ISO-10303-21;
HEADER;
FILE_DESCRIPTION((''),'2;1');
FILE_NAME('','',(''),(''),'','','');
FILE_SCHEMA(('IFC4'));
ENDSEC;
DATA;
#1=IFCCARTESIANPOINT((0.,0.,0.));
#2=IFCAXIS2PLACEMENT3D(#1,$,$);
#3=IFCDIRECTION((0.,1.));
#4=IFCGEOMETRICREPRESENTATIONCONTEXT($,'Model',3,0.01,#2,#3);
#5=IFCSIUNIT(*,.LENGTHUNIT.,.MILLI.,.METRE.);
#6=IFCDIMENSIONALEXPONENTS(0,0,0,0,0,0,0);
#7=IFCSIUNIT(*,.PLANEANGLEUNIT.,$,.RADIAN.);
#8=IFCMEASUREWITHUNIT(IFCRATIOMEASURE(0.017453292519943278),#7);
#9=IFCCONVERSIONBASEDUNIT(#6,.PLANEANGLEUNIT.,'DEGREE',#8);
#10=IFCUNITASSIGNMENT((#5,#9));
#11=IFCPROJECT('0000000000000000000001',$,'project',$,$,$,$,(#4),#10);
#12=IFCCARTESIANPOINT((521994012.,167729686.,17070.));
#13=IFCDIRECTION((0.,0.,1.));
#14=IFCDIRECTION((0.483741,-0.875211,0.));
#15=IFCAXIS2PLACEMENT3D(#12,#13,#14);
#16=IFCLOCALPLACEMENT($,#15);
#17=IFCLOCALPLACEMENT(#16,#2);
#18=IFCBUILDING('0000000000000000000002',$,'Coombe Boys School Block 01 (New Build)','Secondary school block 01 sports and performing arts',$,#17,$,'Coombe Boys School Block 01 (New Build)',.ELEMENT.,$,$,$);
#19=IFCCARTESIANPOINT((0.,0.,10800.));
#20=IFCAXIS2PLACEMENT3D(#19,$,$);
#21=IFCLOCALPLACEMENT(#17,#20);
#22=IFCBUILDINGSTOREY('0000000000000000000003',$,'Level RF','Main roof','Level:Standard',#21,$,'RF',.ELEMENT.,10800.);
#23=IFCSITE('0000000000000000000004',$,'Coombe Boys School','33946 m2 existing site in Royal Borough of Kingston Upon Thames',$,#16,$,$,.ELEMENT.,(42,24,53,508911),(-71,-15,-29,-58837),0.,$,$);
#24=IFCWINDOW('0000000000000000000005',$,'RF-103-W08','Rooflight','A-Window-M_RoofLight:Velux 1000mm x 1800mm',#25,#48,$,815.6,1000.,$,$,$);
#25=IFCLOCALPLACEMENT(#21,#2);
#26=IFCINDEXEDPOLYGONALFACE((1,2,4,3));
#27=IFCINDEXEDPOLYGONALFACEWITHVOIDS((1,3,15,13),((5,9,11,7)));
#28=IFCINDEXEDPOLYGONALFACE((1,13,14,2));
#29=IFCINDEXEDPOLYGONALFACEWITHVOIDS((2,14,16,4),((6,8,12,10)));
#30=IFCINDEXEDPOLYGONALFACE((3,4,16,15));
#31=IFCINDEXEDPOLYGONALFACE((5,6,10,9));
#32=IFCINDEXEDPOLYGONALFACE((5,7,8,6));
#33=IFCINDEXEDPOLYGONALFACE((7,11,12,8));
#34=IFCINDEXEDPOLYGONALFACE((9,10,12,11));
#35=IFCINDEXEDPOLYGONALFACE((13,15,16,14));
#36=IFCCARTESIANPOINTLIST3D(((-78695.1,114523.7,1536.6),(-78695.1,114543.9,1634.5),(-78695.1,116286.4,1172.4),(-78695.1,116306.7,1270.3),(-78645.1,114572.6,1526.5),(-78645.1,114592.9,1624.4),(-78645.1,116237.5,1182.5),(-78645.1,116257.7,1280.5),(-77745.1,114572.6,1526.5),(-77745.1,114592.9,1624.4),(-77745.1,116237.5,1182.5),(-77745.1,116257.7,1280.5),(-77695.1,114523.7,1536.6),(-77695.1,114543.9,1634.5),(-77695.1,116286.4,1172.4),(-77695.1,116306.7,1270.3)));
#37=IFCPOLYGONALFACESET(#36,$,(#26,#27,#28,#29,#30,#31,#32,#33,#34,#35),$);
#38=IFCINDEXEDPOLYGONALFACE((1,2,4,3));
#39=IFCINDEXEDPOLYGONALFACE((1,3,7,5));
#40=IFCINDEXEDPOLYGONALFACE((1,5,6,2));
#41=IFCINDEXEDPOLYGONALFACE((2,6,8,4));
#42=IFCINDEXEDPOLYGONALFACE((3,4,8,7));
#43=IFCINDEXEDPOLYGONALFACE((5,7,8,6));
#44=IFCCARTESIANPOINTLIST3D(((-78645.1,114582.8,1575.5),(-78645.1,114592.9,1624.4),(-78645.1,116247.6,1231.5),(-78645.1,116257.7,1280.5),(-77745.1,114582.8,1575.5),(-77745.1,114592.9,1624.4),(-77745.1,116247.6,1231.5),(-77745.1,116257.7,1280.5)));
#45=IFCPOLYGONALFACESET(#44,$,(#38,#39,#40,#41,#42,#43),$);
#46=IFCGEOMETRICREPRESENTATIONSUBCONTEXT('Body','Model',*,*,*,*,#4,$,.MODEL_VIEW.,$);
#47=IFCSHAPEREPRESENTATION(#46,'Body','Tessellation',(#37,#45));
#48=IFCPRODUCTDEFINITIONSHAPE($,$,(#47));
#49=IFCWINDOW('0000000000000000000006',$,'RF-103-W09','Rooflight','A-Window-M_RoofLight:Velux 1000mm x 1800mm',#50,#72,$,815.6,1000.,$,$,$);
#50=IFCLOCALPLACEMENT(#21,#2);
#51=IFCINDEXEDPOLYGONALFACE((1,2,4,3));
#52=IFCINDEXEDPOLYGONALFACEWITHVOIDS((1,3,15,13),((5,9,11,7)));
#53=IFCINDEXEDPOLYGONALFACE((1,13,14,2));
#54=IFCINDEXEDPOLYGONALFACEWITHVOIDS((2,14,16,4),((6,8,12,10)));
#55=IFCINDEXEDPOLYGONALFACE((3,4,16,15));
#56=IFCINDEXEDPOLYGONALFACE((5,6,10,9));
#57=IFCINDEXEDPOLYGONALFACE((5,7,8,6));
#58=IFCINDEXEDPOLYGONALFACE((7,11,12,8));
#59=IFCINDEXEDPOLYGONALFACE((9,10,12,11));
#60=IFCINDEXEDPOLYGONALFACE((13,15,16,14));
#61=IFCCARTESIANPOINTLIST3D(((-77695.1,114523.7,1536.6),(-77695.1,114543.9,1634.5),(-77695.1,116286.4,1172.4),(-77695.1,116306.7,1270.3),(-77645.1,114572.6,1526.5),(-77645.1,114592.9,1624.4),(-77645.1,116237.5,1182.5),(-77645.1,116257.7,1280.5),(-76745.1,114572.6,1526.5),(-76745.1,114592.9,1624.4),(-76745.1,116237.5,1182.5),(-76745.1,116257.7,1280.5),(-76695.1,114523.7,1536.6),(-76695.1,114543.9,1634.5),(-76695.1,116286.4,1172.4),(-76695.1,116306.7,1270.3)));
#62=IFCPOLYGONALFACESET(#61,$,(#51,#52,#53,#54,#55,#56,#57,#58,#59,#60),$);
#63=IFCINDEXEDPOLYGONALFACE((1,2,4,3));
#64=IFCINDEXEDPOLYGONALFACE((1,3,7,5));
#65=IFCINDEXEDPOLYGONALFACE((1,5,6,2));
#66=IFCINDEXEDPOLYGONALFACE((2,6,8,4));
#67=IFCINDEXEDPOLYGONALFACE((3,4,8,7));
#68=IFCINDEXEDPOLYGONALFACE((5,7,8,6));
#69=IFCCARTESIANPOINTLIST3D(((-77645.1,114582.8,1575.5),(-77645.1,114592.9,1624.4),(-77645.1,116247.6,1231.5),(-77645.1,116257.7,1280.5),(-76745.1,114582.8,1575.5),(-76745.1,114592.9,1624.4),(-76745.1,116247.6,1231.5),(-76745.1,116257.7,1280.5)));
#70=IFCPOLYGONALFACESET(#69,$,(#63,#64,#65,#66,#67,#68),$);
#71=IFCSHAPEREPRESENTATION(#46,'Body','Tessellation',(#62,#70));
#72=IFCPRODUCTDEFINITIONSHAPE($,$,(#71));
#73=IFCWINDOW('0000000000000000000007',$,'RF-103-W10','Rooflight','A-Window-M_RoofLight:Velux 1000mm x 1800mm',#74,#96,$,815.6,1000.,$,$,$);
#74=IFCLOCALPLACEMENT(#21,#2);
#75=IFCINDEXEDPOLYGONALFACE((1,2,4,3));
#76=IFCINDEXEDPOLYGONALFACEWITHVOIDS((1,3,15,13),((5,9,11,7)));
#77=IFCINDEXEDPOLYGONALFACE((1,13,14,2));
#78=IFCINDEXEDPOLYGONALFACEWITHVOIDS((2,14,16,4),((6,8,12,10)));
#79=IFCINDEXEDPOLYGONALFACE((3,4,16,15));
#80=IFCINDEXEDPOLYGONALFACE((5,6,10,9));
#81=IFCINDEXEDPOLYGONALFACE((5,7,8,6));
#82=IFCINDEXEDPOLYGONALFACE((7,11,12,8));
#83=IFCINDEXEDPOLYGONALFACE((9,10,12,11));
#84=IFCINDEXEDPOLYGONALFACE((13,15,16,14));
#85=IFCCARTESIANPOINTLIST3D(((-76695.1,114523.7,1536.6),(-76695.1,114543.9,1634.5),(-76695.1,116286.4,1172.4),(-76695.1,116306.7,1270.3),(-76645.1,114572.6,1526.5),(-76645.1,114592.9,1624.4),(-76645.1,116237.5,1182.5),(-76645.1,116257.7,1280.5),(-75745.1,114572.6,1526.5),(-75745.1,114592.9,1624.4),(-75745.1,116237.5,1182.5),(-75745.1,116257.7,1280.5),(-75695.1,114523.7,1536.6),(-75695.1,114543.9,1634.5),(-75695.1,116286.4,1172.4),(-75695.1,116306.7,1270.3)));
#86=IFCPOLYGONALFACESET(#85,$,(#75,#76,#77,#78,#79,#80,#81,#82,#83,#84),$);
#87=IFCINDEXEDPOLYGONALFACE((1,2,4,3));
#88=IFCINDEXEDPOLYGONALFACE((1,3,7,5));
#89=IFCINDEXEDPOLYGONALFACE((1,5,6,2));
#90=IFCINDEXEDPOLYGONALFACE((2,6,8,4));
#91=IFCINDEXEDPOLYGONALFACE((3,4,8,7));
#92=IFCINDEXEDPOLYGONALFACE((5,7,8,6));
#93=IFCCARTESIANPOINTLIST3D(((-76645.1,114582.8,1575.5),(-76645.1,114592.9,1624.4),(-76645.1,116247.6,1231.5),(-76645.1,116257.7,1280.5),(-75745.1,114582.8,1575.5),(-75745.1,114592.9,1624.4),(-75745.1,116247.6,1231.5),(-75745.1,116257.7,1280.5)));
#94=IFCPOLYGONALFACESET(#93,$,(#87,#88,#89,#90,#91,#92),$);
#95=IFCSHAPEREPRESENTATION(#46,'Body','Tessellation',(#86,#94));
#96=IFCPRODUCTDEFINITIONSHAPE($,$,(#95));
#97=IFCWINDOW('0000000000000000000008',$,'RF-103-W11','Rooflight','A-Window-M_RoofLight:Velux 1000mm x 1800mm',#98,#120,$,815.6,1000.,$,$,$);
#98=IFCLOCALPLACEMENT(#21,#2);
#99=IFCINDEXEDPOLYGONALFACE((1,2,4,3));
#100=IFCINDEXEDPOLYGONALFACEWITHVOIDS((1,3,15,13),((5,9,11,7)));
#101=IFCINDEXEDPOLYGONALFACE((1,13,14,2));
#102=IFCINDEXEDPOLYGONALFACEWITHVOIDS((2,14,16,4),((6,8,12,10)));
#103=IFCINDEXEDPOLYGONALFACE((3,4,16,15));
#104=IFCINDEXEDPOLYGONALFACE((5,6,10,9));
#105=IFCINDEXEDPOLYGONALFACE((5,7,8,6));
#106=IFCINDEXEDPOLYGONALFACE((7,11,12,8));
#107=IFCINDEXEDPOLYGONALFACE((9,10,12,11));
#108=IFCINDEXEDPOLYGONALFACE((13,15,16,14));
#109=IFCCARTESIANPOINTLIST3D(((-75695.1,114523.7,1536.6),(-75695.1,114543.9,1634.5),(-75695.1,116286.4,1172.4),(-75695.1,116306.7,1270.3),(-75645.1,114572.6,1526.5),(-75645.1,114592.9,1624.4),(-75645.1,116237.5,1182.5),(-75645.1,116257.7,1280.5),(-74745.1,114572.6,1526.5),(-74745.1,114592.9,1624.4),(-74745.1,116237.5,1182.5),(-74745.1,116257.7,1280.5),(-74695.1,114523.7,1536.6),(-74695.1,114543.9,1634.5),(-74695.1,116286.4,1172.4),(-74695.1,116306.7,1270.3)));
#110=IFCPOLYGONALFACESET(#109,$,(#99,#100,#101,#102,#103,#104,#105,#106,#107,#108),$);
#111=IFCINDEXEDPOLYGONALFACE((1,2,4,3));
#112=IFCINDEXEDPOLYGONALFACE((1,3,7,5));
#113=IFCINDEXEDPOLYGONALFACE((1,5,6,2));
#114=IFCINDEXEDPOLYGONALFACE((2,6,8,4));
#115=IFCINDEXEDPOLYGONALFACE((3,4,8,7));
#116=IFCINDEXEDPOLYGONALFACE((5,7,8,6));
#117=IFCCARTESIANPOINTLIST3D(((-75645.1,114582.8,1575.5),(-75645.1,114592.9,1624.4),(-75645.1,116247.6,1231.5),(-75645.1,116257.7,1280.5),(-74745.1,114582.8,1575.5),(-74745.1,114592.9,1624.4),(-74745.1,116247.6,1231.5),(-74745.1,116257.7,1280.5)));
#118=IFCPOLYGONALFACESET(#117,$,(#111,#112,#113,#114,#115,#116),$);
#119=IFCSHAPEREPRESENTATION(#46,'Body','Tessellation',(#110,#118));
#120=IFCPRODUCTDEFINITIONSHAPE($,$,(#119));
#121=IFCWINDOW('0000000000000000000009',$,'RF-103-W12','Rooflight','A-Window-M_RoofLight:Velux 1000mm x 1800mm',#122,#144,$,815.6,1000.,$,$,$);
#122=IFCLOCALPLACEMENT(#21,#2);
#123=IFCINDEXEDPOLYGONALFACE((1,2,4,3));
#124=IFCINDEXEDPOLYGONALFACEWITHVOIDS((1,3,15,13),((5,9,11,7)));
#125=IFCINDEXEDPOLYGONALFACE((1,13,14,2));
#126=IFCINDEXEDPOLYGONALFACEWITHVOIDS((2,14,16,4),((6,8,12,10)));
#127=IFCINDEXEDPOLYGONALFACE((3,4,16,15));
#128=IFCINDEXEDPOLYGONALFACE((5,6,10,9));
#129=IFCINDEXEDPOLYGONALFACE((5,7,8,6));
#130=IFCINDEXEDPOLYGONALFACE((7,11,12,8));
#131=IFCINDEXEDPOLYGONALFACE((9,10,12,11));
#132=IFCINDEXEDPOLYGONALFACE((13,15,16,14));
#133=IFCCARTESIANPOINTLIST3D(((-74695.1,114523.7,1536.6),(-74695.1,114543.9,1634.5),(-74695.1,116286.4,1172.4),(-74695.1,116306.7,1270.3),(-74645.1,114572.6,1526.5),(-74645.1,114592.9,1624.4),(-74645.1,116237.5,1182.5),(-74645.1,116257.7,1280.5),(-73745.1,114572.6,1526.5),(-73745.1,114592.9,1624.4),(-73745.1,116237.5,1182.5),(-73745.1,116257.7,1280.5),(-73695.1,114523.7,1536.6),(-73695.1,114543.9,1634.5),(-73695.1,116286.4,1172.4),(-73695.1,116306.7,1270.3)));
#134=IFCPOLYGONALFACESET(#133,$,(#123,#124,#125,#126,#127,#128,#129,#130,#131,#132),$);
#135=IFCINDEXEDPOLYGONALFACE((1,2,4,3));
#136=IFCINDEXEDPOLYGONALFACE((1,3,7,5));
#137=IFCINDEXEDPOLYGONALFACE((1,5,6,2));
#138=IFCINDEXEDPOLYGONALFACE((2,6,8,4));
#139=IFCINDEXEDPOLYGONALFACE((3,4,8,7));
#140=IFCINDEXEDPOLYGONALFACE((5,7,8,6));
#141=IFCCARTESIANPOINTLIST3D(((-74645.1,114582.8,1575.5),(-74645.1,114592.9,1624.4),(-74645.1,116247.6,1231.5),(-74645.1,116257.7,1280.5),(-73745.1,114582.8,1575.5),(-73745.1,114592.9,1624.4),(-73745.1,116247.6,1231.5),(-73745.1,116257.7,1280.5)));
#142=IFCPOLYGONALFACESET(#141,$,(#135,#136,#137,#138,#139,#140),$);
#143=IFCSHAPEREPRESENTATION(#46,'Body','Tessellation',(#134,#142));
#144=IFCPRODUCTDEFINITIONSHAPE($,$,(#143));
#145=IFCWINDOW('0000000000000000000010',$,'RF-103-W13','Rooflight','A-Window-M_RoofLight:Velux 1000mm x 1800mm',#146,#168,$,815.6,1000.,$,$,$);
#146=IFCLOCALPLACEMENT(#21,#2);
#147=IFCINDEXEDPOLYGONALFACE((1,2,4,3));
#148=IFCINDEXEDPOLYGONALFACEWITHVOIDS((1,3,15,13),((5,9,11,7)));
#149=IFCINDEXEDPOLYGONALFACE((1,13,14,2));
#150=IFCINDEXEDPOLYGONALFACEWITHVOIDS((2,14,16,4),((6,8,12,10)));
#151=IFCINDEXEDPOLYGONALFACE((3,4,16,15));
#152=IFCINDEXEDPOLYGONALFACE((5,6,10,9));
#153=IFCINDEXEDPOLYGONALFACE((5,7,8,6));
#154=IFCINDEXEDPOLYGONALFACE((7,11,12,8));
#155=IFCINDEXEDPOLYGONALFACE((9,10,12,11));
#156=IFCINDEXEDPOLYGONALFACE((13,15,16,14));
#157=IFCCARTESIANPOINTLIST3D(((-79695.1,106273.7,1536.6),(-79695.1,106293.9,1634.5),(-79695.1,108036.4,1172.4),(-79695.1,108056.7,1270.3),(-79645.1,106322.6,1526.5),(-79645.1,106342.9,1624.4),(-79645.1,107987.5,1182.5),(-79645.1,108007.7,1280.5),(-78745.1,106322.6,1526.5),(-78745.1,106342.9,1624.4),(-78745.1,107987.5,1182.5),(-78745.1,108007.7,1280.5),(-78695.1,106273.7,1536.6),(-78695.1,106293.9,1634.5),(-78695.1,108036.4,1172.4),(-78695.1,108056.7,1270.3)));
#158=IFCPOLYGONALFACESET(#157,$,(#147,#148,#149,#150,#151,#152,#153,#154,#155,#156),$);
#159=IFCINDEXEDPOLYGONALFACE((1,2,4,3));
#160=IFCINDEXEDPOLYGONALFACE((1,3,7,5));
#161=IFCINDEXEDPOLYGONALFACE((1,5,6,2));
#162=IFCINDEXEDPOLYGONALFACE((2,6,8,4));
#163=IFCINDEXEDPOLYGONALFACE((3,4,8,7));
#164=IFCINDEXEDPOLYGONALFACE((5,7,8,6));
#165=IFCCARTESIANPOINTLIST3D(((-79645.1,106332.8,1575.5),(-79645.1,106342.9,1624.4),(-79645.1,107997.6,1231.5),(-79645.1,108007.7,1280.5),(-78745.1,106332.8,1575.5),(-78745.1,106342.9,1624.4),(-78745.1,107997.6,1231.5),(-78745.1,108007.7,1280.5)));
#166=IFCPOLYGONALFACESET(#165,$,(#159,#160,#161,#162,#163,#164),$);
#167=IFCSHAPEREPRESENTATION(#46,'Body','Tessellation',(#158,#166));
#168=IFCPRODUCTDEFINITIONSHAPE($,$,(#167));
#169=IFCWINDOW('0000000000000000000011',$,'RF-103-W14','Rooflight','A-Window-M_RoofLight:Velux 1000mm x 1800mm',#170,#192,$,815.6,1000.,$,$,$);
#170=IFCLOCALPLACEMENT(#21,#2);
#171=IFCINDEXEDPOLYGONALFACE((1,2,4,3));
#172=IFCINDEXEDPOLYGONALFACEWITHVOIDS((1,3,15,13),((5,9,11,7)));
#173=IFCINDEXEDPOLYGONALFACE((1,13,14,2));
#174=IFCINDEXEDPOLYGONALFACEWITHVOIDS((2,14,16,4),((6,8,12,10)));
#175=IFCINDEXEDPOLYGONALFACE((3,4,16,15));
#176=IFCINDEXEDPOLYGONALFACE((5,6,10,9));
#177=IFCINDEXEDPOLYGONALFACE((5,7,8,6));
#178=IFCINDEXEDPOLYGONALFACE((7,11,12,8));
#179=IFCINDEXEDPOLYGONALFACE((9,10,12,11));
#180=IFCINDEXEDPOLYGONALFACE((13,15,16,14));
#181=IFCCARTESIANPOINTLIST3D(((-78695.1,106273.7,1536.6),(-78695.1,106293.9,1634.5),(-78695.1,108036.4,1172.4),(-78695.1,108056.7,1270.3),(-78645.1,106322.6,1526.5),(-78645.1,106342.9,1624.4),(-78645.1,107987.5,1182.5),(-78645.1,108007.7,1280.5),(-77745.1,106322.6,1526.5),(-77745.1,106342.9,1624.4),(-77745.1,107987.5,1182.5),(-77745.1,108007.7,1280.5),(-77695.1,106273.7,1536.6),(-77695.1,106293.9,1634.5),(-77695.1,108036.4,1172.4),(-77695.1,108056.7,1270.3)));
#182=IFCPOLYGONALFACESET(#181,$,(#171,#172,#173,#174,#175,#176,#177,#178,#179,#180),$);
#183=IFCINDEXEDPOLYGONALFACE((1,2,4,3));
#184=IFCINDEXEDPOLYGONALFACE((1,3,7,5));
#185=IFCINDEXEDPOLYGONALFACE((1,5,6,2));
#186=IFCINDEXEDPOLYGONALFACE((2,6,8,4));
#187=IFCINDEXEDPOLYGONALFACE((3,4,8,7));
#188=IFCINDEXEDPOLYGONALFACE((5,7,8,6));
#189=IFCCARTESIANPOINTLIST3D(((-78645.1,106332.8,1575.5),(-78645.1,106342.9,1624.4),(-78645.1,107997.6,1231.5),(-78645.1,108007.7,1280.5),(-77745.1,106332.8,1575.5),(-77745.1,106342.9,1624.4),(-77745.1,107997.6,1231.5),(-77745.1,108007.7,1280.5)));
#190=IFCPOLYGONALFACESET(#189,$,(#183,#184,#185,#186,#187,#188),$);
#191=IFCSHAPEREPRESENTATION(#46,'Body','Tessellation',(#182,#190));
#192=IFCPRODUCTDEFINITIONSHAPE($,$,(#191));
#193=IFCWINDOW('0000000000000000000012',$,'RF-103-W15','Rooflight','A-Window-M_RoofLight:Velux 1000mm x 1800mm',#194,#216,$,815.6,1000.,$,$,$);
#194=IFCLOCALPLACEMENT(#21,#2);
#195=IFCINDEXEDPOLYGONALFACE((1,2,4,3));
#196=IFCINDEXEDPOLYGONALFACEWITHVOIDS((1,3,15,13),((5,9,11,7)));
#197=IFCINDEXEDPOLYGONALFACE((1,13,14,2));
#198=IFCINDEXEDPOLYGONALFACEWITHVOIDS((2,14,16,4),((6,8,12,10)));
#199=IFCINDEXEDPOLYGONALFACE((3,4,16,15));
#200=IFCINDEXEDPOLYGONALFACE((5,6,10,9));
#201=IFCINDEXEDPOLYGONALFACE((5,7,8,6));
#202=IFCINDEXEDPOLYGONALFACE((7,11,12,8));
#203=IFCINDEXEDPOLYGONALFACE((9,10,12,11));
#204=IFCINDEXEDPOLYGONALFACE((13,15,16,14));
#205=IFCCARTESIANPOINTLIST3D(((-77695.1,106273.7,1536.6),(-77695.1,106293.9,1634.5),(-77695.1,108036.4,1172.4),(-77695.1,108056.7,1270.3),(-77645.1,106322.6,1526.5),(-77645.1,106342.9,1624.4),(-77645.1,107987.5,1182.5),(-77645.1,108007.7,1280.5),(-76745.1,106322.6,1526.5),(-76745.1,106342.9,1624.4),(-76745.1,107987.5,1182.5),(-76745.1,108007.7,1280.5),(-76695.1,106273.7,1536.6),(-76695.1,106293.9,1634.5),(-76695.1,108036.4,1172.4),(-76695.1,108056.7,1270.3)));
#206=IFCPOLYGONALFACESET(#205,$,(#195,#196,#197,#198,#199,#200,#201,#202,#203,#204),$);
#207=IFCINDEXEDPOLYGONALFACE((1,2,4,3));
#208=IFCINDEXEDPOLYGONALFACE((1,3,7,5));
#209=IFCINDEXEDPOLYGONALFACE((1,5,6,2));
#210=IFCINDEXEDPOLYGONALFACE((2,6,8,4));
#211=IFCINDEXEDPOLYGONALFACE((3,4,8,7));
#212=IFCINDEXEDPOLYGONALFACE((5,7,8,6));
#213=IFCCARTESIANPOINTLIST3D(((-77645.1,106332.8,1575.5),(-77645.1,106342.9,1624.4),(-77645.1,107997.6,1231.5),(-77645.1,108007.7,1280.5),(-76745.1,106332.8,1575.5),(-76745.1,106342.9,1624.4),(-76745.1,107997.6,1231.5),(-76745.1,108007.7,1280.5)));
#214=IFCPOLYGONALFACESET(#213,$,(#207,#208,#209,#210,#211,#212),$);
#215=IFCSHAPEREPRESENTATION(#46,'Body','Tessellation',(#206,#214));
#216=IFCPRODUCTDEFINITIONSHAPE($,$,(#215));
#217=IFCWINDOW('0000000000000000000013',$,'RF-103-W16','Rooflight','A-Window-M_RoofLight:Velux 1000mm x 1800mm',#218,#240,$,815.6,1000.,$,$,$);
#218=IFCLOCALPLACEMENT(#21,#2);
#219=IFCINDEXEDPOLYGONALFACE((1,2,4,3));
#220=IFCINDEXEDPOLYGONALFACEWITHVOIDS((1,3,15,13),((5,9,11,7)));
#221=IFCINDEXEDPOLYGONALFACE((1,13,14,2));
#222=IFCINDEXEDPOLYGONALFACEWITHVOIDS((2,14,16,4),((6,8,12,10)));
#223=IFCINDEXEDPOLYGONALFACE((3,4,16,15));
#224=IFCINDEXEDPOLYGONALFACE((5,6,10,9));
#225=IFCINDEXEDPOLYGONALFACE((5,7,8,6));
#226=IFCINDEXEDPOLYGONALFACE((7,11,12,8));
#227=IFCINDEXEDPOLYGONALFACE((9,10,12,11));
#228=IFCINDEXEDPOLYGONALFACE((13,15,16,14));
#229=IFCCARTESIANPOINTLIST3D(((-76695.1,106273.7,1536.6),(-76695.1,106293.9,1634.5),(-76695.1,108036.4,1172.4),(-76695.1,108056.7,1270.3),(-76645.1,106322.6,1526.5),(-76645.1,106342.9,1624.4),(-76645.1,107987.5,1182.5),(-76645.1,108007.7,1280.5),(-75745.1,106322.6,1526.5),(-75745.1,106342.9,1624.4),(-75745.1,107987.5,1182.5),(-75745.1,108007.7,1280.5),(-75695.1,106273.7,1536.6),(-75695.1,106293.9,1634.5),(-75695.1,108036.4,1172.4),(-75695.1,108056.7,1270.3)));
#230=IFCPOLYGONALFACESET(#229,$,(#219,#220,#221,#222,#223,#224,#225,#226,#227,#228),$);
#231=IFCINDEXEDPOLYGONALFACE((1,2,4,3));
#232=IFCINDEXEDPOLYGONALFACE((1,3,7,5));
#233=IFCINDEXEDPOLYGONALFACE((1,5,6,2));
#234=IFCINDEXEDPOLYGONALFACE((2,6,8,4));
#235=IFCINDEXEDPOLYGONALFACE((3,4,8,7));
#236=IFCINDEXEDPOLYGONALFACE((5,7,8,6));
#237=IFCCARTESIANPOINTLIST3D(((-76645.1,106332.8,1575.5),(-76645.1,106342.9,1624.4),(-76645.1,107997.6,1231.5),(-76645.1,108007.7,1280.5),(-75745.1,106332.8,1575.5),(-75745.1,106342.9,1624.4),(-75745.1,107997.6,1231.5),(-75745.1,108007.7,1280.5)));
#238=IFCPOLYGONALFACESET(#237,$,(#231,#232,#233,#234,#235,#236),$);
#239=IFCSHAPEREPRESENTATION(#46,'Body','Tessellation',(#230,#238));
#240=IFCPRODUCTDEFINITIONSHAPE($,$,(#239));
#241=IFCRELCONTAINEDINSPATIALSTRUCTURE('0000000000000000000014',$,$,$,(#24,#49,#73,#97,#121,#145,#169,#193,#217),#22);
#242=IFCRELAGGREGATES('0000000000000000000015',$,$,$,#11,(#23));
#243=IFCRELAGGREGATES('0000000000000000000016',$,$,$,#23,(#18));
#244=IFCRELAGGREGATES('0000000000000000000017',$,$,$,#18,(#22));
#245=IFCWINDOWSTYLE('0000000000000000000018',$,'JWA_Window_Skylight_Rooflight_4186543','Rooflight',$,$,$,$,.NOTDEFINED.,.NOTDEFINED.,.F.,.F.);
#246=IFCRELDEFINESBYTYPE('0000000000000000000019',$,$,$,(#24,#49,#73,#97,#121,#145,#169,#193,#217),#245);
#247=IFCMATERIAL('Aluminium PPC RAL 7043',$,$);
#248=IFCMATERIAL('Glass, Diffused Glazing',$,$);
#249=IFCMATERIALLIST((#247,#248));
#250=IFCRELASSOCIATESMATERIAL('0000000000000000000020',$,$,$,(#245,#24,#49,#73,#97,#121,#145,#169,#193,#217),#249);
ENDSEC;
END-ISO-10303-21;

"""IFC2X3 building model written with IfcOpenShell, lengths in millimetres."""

from ifc_helpers import new_model, entity, si_unit, converted_unit, direction, frame, frame_2d, origin, place, context, subcontext, project, spatial, polyline, rectangle, outline, extrude, source, transform, mapped, material, material_list, type_object, type_shapes, element, save


model = new_model("IFC2X3")

# Units and contexts
model_context = context("Model", 3, precision=0.01, world=origin(), true_north=direction((0.0, 1.0)))
body_context = subcontext(model_context, "Body", "Model", "MODEL_VIEW")
ifc_project = project(units=[si_unit("LENGTHUNIT", "METRE", prefix="MILLI"), converted_unit("PLANEANGLEUNIT", "DEGREE", entity("IfcRatioMeasure", 0.017453292519943278), si_unit("PLANEANGLEUNIT", "RADIAN"), dimensions=[0, 0, 0, 0, 0, 0, 0])], contexts=[model_context])

# Site, building, storey
site_placement = place(None, frame((521994012.0, 167729686.0, 17070.0), z_axis=(0.0, 0.0, 1.0), x_axis=(0.483741, -0.875211, 0.0)))
site = spatial("IfcSite", under=ifc_project, at=site_placement, Name="Coombe Boys School", Description="33946 m2 existing site in Royal Borough of Kingston Upon Thames", CompositionType="ELEMENT", RefLatitude=(42, 24, 53, 508911), RefLongitude=(-71, -15, -29, -58837), RefElevation=0.0)
building_placement = place(site_placement, origin())
building = spatial("IfcBuilding", under=site, at=building_placement, Name="Coombe Boys School Block 01 (New Build)", Description="Secondary school block 01 sports and performing arts", LongName="Coombe Boys School Block 01 (New Build)", CompositionType="ELEMENT")
storey_placement = place(building_placement, frame((0.0, 0.0, 10800.0)))
storey = spatial("IfcBuildingStorey", under=building, at=storey_placement, Name="Level RF", Description="Main roof", ObjectType="Level:Standard", LongName="RF", CompositionType="ELEMENT", Elevation=10800.0)

# Windows
ifc_material_1 = material(Name="Aluminium PPC RAL 7043")
ifc_material_2 = material(Name="Glass, Diffused Glazing")
ifc_material_list = material_list([ifc_material_1, ifc_material_2])
window_style = type_object("IfcWindowStyle", Name="JWA_Window_Skylight_Rooflight_4186543", Description="Rooflight", ConstructionType="NOTDEFINED", OperationType="NOTDEFINED", ParameterTakesPrecedence=False, Sizeable=False, material=ifc_material_list)
shared_shape_1 = source(origin(), body_context, "Body", "SweptSolid", [
    extrude(outline(polyline([(-500.0, -900.0), (500.0, -900.0), (500.0, 900.0), (-500.0, 900.0), (-500.0, -900.0)]), holes=[polyline([(-450.0, -850.0), (-450.0, 850.0), (450.0, 850.0), (450.0, -850.0), (-450.0, -850.0)])]), frame((0.0, 0.0, 4100.0), z_axis=(0.0, 0.0, 1.0), x_axis=(-1.0, 0.0, 0.0)), (0.0, 0.0, 1.0), 100.0),
    extrude(rectangle(XDim=900.0, YDim=1700.0, at=frame_2d((0.0, 0.0), x_axis=(1.0, 0.0))), frame((0.0, 0.0, 4150.0), z_axis=(0.0, 0.0, 1.0), x_axis=(-1.0, 0.0, 0.0)), (0.0, 0.0, 1.0), 50.0),
])
type_shapes(window_style, [shared_shape_1])
for number, where, z_axis, x_axis, name in (
    (1, (-78195.1, 114575.5, -2660.7), (0.0, 0.202338, 0.979316), (-1.0, 0.0, 0.0), "RF-103-W08"),
    (2, (-77195.1, 114575.5, -2660.7), (0.0, 0.202338, 0.979316), (-1.0, 0.0, 0.0), "RF-103-W09"),
    (3, (-76195.1, 114575.5, -2660.7), (0.0, 0.202338, 0.979316), (-1.0, 0.0, 0.0), "RF-103-W10"),
    (4, (-75195.1, 114575.5, -2660.7), (0.0, 0.202338, 0.979316), (-1.0, 0.0, 0.0), "RF-103-W11"),
    (5, (-74195.1, 114575.5, -2660.7), (0.0, 0.202338, 0.979316), (-1.0, 0.0, 0.0), "RF-103-W12"),
    (6, (-79195.1, 106325.5, -2660.7), (0.0, 0.202338, 0.979316), (-1.0, 0.0, 0.0), "RF-103-W13"),
    (7, (-78195.1, 106325.5, -2660.7), (0.0, 0.202338, 0.979316), (-1.0, 0.0, 0.0), "RF-103-W14"),
    (8, (-77195.1, 106325.5, -2660.7), (0.0, 0.202338, 0.979316), (-1.0, 0.0, 0.0), "RF-103-W15"),
    (9, (-76195.1, 106325.5, -2660.7), (0.0, 0.202338, 0.979316), (-1.0, 0.0, 0.0), "RF-103-W16"),
):
    element("IfcWindow", number, at=place(storey_placement, frame(where, z_axis=z_axis, x_axis=x_axis)), inside=storey, type_object=window_style, material=ifc_material_list, Name=name, Description="Rooflight", ObjectType="A-Window-M_RoofLight:Velux 1000mm x 1800mm", OverallHeight=815.6, OverallWidth=1000.0, context=body_context, shape_type="MappedRepresentation", body=[
        mapped(shared_shape_1, transform((0.0, 0.0, 0.0), scale=1.0)),
    ])

save(model, "model.ifc")
